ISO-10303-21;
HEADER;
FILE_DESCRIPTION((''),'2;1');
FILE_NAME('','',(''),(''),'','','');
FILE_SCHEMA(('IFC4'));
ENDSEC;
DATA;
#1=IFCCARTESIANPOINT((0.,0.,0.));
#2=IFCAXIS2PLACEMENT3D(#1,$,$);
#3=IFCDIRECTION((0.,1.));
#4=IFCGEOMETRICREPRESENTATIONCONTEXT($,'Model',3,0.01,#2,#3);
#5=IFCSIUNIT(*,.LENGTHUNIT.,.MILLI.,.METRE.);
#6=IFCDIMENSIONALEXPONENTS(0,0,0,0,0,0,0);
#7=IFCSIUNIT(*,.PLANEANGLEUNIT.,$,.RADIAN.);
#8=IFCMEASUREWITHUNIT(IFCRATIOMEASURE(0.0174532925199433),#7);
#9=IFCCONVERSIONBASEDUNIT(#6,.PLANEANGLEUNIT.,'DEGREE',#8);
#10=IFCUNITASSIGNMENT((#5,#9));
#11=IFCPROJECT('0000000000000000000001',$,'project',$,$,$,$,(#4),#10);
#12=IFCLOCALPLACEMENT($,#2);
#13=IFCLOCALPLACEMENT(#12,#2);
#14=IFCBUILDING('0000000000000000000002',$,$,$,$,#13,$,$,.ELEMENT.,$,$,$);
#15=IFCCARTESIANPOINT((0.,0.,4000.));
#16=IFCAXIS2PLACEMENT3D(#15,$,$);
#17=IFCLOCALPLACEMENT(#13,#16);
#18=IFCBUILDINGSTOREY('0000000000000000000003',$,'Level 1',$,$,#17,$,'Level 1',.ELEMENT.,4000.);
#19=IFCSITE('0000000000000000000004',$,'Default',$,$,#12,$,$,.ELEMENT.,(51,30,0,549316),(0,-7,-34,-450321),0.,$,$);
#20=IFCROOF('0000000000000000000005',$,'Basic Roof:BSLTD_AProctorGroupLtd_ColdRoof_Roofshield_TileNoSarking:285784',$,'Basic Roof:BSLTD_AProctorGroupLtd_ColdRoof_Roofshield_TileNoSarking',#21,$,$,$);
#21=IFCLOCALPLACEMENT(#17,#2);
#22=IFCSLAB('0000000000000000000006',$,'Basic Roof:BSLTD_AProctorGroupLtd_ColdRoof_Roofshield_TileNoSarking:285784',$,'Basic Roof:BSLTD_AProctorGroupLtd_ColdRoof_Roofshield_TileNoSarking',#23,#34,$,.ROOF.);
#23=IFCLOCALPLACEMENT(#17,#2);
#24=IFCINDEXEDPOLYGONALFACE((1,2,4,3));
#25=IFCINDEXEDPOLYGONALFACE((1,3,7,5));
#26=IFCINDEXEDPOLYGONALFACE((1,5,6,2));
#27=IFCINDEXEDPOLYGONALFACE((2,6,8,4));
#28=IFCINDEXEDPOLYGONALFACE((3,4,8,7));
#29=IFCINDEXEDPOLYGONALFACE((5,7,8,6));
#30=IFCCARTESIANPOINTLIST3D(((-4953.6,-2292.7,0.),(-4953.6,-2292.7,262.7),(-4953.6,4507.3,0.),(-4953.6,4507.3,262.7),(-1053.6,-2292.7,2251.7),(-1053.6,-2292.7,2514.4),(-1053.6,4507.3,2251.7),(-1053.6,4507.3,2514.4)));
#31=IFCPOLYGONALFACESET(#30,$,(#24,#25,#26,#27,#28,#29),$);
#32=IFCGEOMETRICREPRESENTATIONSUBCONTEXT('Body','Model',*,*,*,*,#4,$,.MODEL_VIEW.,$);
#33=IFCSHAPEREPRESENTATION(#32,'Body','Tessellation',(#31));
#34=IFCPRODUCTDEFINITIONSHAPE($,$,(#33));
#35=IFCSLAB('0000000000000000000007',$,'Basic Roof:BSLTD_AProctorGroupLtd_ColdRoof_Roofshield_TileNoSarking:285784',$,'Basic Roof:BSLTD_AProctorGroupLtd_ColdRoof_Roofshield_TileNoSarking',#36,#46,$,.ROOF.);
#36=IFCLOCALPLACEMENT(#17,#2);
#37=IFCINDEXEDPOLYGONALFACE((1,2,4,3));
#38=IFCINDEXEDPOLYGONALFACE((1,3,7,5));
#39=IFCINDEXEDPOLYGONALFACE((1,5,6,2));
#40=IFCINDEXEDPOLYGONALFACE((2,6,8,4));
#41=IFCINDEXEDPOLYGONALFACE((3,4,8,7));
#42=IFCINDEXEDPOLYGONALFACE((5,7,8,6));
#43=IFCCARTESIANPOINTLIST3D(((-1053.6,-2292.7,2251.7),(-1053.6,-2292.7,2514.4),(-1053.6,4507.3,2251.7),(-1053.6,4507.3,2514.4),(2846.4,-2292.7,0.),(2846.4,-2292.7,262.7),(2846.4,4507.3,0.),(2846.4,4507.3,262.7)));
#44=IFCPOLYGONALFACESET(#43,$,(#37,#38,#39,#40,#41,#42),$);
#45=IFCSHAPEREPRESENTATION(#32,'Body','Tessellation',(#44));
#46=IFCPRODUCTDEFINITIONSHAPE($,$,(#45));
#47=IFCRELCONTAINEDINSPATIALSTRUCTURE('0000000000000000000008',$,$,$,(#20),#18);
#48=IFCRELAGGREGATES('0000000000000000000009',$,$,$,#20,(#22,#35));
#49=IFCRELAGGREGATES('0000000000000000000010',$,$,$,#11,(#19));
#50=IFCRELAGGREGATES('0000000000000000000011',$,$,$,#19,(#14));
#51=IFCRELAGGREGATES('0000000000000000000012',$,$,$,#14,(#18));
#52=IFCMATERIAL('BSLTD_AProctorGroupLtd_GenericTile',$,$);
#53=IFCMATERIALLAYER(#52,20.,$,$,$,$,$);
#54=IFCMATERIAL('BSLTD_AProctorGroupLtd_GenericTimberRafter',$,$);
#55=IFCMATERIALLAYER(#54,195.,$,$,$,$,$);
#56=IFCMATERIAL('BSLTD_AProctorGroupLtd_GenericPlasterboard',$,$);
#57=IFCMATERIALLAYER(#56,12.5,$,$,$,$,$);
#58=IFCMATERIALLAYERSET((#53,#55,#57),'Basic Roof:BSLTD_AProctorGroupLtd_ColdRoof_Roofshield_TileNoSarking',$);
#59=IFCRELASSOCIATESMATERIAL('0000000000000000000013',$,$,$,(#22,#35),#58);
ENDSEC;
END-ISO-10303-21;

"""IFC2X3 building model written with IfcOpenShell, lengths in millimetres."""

from ifc_helpers import new_model, entity, si_unit, converted_unit, direction, frame, frame_2d, origin, place, context, subcontext, project, spatial, rectangle, extrude, material, layer, layer_set, element, aggregate, save


model = new_model("IFC2X3")

# Units and contexts
model_context = context("Model", 3, precision=0.01, world=origin(), true_north=direction((0.0, 1.0)))
body_context = subcontext(model_context, "Body", "Model", "MODEL_VIEW")
ifc_project = project(units=[si_unit("LENGTHUNIT", "METRE", prefix="MILLI"), converted_unit("PLANEANGLEUNIT", "DEGREE", entity("IfcRatioMeasure", 0.0174532925199433), si_unit("PLANEANGLEUNIT", "RADIAN"), dimensions=[0, 0, 0, 0, 0, 0, 0])], contexts=[model_context])

# Site, building, storey
site_placement = place(None, origin())
site = spatial("IfcSite", under=ifc_project, at=site_placement, Name="Default", CompositionType="ELEMENT", RefLatitude=(51, 30, 0, 549316), RefLongitude=(0, -7, -34, -450321), RefElevation=0.0)
building_placement = place(site_placement, origin())
building = spatial("IfcBuilding", under=site, at=building_placement, CompositionType="ELEMENT")
storey_placement = place(building_placement, frame((0.0, 0.0, 4000.0)))
storey = spatial("IfcBuildingStorey", under=building, at=storey_placement, Name="Level 1", LongName="Level 1", CompositionType="ELEMENT", Elevation=4000.0)

# Roof, slabs
roof_placement = place(storey_placement, frame((-4953.6, -2292.7, 0.0)))
roof = element("IfcRoof", 1, at=roof_placement, inside=storey, Name="Basic Roof:BSLTD_AProctorGroupLtd_ColdRoof_Roofshield_TileNoSarking:285784", ObjectType="Basic Roof:BSLTD_AProctorGroupLtd_ColdRoof_Roofshield_TileNoSarking")
ifc_material_1 = material(Name="BSLTD_AProctorGroupLtd_GenericTile")
ifc_layer_1 = layer(ifc_material_1, 20.0)
ifc_material_2 = material(Name="BSLTD_AProctorGroupLtd_GenericTimberRafter")
ifc_layer_2 = layer(ifc_material_2, 195.0)
ifc_material_3 = material(Name="BSLTD_AProctorGroupLtd_GenericPlasterboard")
ifc_layer_3 = layer(ifc_material_3, 12.5)
ifc_layer_set = layer_set([ifc_layer_1, ifc_layer_2, ifc_layer_3], Name="Basic Roof:BSLTD_AProctorGroupLtd_ColdRoof_Roofshield_TileNoSarking")
slab_1_placement = place(roof_placement, origin())
slab_1 = element("IfcSlab", 2, at=slab_1_placement, material=ifc_layer_set, Name="Basic Roof:BSLTD_AProctorGroupLtd_ColdRoof_Roofshield_TileNoSarking:285784", ObjectType="Basic Roof:BSLTD_AProctorGroupLtd_ColdRoof_Roofshield_TileNoSarking", PredefinedType="ROOF", context=body_context, shape_type="SweptSolid", body=[
    extrude(rectangle(XDim=4503.3, YDim=6800.0, at=frame_2d((0.0, 0.0), x_axis=(-1.0, 0.0))), frame((1950.0, 3400.0, 1125.8), z_axis=(-0.5, 0.0, 0.866025), x_axis=(0.866025, 0.0, 0.5)), (0.5, 0.0, 0.866025), 262.7),
])
slab_2_placement = place(roof_placement, origin())
slab_2 = element("IfcSlab", 3, at=slab_2_placement, material=ifc_layer_set, Name="Basic Roof:BSLTD_AProctorGroupLtd_ColdRoof_Roofshield_TileNoSarking:285784", ObjectType="Basic Roof:BSLTD_AProctorGroupLtd_ColdRoof_Roofshield_TileNoSarking", PredefinedType="ROOF", context=body_context, shape_type="SweptSolid", body=[
    extrude(rectangle(XDim=6800.0, YDim=4503.3, at=frame_2d((0.0, 0.0), x_axis=(0.0, -1.0))), frame((5850.0, 3400.0, 1125.8), z_axis=(0.5, 0.0, 0.866025), x_axis=(0.866025, 0.0, -0.5)), (-0.5, 0.0, 0.866025), 262.7),
])
aggregate(roof, [slab_1, slab_2])

save(model, "model.ifc")
